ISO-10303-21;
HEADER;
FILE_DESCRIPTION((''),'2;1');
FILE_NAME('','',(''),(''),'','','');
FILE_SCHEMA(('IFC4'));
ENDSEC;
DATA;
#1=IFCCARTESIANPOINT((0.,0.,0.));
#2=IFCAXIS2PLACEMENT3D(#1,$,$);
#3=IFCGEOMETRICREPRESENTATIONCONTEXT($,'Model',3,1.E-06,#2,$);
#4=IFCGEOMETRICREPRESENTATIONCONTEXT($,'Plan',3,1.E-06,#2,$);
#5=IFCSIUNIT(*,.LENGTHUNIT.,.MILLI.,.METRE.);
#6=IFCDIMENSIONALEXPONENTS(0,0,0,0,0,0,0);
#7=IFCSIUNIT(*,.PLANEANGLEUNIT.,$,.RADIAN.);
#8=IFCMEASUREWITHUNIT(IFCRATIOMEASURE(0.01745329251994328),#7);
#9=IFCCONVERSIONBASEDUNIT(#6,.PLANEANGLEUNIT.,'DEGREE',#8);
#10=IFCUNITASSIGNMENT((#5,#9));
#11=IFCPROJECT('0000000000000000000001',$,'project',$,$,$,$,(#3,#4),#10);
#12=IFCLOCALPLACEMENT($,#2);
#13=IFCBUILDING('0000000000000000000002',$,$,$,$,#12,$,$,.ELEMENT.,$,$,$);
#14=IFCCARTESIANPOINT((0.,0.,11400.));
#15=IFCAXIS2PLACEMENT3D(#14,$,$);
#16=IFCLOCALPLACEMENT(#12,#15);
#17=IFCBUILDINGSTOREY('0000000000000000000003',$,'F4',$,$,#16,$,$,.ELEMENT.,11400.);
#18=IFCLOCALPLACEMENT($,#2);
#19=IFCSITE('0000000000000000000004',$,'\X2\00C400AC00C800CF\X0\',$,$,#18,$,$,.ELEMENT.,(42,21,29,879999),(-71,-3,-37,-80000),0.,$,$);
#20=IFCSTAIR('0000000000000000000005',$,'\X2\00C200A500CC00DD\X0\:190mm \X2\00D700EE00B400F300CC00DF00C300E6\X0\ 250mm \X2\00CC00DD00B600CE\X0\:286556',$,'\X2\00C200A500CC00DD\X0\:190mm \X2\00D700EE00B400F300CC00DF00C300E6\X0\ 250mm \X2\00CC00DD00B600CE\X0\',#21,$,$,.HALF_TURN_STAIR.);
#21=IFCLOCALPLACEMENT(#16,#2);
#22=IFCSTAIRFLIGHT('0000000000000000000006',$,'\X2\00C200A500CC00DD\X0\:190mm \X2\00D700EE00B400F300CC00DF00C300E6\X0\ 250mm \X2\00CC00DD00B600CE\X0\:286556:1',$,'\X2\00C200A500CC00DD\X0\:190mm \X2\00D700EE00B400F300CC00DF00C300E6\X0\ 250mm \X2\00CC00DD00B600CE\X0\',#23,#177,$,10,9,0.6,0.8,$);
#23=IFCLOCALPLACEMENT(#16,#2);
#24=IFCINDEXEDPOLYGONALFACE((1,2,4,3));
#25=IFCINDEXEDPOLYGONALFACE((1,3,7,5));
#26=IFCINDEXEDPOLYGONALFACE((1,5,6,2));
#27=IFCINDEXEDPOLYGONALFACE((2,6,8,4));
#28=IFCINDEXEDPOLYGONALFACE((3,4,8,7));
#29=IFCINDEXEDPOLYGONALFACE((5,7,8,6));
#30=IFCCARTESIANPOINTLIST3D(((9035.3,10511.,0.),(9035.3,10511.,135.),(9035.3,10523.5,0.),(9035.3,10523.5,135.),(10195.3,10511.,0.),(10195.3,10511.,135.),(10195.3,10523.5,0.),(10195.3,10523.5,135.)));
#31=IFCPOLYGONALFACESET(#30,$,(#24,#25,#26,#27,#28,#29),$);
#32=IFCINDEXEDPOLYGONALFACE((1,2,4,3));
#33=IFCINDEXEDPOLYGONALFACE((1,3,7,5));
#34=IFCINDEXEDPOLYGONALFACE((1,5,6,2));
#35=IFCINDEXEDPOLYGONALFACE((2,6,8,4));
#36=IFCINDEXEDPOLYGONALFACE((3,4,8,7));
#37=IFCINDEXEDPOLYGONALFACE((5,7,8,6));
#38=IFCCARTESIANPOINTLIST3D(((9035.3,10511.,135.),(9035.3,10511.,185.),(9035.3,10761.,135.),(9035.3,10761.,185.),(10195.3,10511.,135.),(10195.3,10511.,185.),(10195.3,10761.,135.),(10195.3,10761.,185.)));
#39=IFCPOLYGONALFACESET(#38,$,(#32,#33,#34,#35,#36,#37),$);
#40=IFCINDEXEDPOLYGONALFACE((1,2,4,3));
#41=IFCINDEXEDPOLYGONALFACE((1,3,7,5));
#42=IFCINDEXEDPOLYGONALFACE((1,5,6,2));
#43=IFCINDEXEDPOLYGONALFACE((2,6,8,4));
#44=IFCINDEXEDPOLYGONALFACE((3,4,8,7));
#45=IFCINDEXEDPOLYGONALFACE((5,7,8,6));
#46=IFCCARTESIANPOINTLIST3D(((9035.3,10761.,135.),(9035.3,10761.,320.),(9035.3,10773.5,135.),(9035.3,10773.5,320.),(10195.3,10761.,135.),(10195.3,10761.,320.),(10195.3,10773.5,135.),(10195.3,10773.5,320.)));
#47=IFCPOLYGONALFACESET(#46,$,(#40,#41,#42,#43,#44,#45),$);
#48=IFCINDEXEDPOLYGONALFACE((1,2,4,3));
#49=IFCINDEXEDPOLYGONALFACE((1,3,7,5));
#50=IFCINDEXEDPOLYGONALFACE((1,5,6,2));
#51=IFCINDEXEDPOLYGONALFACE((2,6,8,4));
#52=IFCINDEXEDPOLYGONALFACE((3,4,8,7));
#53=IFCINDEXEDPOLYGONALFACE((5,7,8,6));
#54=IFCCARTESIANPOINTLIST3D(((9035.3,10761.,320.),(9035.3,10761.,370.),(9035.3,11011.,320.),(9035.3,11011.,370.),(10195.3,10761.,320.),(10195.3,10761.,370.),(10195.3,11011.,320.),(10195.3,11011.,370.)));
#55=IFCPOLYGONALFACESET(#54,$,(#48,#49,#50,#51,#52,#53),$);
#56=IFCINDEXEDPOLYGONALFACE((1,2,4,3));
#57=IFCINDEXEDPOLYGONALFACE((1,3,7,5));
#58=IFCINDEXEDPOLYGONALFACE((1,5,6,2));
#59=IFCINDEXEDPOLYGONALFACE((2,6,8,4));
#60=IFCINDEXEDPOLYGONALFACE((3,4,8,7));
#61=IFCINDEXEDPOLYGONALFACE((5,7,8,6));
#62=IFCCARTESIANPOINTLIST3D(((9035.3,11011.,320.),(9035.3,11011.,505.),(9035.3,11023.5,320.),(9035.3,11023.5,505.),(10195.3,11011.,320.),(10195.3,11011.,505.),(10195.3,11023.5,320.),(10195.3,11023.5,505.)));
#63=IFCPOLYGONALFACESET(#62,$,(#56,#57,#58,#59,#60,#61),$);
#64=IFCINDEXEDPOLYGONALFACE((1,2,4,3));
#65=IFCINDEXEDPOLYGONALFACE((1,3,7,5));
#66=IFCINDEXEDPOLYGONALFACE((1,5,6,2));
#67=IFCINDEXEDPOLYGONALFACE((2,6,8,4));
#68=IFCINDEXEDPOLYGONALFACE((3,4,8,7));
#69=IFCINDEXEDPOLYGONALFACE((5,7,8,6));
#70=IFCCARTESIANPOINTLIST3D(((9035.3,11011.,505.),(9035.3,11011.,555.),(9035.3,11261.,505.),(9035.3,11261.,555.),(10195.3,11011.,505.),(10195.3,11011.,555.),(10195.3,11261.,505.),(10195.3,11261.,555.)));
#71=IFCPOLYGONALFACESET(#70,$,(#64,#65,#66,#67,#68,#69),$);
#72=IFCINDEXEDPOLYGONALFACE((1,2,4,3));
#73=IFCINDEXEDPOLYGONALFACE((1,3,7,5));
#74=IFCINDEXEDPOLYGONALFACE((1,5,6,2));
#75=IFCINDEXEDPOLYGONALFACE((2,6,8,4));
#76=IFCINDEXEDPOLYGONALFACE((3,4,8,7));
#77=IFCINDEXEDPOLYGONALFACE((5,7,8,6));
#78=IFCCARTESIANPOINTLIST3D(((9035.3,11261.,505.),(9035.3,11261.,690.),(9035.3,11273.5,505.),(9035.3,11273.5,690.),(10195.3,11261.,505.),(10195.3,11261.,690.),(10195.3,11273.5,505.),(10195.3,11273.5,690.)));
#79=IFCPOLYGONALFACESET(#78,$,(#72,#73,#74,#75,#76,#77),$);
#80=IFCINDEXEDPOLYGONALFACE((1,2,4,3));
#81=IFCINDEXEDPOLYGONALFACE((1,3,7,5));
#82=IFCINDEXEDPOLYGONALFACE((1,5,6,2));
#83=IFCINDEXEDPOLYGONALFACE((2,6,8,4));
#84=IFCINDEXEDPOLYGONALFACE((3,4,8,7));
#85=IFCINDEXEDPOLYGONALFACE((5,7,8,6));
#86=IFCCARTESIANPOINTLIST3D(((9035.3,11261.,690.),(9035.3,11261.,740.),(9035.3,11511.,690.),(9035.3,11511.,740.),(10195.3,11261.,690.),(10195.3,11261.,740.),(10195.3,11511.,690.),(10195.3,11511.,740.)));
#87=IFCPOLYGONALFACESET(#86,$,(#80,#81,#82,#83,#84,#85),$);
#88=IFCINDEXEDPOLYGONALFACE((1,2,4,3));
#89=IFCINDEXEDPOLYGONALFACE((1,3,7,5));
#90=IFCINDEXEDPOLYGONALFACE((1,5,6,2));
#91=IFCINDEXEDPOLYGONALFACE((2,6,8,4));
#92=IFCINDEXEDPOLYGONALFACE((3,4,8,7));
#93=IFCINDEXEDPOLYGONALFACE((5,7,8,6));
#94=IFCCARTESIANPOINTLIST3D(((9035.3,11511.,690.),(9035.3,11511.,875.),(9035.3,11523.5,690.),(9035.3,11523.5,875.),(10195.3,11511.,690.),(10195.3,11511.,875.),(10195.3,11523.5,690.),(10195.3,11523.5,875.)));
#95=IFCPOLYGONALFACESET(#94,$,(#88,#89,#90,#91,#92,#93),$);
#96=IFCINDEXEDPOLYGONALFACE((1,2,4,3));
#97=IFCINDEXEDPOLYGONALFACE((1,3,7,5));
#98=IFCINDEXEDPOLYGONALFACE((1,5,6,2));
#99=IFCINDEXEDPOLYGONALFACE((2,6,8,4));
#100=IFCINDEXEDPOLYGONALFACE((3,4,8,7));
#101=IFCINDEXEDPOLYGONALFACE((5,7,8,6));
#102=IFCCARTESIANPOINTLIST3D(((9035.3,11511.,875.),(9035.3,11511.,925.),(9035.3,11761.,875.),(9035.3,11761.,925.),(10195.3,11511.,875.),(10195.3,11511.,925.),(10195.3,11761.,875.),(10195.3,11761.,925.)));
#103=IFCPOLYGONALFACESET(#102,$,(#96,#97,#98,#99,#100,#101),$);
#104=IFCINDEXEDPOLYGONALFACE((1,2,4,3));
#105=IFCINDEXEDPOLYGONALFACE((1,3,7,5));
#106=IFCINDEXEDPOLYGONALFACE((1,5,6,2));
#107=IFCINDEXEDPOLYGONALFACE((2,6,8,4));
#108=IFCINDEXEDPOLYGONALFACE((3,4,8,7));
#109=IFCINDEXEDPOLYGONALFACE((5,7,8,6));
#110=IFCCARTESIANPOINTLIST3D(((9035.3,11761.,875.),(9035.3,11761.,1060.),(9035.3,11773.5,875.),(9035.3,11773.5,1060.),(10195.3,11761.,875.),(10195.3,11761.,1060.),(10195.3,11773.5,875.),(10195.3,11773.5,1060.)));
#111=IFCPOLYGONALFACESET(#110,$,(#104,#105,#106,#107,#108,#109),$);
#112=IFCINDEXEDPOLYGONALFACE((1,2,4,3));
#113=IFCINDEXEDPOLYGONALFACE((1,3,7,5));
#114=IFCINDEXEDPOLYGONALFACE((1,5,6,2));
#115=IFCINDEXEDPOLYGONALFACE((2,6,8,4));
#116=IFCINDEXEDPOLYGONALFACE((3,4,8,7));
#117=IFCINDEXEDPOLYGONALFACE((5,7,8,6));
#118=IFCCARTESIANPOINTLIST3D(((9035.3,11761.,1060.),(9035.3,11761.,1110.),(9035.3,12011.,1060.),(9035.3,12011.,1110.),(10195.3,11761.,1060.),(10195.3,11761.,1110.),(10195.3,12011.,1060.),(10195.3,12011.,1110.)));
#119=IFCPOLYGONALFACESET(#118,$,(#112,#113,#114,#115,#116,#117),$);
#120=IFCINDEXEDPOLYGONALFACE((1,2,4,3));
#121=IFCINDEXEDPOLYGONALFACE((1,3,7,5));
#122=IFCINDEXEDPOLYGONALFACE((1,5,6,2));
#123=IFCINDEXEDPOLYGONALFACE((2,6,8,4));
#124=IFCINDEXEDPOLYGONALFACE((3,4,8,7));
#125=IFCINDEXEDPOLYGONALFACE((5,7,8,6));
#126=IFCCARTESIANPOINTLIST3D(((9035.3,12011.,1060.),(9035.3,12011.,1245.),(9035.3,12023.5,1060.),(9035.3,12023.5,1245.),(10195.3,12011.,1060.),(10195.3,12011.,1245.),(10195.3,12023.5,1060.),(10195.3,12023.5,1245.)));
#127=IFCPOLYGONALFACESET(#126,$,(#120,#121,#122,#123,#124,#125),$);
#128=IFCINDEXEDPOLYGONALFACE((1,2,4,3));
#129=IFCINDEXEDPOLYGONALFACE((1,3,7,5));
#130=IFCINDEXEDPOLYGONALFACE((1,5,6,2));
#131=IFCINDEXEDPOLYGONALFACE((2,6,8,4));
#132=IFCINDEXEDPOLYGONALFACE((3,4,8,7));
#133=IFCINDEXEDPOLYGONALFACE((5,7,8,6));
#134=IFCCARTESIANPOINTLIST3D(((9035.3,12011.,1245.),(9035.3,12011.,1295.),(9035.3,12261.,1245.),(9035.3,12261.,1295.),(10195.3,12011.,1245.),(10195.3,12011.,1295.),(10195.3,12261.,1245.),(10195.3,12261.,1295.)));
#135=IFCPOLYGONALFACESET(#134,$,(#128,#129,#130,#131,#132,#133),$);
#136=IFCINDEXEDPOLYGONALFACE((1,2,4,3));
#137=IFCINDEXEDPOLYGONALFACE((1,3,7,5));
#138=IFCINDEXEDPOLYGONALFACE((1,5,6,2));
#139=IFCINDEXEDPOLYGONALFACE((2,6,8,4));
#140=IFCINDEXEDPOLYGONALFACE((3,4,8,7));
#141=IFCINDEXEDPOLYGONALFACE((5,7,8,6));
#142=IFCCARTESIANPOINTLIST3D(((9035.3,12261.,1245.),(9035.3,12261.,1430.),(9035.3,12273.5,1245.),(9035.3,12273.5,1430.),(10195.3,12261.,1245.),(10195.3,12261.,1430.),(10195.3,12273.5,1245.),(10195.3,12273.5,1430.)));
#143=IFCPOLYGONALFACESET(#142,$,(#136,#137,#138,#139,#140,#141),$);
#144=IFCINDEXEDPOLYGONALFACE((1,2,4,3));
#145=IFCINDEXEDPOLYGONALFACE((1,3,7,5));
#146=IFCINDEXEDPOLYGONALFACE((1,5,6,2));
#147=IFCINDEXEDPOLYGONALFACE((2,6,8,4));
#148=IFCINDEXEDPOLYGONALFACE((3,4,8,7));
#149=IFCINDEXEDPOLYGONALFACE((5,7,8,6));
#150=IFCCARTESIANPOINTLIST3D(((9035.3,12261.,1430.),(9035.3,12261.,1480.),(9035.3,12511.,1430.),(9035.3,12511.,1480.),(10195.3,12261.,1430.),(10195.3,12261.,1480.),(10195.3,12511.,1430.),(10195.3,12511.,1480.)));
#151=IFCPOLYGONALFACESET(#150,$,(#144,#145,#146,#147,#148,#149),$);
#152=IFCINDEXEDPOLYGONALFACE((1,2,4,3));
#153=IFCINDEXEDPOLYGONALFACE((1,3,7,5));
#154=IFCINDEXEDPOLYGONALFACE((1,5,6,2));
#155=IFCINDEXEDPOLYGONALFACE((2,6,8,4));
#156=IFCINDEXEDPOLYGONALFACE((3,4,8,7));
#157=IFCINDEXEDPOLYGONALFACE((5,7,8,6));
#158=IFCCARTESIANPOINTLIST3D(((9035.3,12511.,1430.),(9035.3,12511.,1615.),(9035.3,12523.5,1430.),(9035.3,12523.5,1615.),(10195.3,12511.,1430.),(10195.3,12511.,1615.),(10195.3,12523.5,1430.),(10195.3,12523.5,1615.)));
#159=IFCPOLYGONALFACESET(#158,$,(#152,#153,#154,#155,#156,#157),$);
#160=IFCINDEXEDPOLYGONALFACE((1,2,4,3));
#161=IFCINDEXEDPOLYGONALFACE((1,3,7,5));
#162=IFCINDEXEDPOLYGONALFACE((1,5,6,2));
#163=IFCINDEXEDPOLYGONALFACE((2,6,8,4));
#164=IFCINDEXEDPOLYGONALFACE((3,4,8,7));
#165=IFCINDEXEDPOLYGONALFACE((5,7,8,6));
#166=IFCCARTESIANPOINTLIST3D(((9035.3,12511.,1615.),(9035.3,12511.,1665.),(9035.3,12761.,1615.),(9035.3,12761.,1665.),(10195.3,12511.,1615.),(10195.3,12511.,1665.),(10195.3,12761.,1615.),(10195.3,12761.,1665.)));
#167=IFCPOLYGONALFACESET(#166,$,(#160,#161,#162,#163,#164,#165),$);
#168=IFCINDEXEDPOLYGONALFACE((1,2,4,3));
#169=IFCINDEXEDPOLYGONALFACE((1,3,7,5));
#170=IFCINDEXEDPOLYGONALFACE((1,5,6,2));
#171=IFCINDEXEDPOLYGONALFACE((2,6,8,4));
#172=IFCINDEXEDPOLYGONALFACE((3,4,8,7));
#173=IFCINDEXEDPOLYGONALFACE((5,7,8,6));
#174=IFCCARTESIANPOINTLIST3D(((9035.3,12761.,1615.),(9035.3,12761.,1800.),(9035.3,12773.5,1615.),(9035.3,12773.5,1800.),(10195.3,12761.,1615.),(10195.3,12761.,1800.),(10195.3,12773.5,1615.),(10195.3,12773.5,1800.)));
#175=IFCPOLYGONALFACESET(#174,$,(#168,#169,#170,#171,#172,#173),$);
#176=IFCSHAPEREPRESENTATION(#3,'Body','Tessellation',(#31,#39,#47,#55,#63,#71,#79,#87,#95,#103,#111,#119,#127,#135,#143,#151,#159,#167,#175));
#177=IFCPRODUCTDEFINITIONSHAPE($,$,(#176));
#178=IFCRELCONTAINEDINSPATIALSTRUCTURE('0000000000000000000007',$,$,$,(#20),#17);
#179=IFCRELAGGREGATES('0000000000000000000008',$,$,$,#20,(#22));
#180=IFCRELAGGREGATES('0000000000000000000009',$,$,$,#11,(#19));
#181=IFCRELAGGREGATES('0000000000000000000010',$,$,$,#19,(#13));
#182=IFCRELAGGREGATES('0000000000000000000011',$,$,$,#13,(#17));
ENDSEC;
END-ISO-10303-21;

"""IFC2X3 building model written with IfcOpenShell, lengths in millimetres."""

from ifc_helpers import new_model, entity, si_unit, converted_unit, frame, origin, origin_2d_with_axis, place, context, project, spatial, rectangle, extrude, element, aggregate, save


model = new_model("IFC2X3")

# Units and contexts
model_context = context("Model", 3, precision=1e-06, world=origin())
plan_context = context("Plan", 3, precision=1e-06, world=origin())
ifc_project = project(units=[si_unit("LENGTHUNIT", "METRE", prefix="MILLI"), converted_unit("PLANEANGLEUNIT", "DEGREE", entity("IfcRatioMeasure", 0.01745329251994328), si_unit("PLANEANGLEUNIT", "RADIAN"), dimensions=[0, 0, 0, 0, 0, 0, 0])], contexts=[model_context, plan_context])

# Site, building, storey
site_placement = place(None, origin())
site = spatial("IfcSite", under=ifc_project, at=site_placement, Name="Ä¬ÈÏ", CompositionType="ELEMENT", RefLatitude=(42, 21, 29, 879999), RefLongitude=(-71, -3, -37, -80000), RefElevation=0.0)
building_placement = place(None, origin())
building = spatial("IfcBuilding", under=site, at=building_placement, CompositionType="ELEMENT")
storey_placement = place(building_placement, frame((0.0, 0.0, 11400.0)))
storey = spatial("IfcBuildingStorey", under=building, at=storey_placement, Name="F4", CompositionType="ELEMENT", Elevation=11400.0)

# Stair
stair_1_placement = place(storey_placement, origin())
stair_1 = element("IfcStair", 1, at=stair_1_placement, inside=storey, Name="Â¥ÌÝ:190mm ×î´óÌßÃæ 250mm ÌÝ¶Î:286556", ObjectType="Â¥ÌÝ:190mm ×î´óÌßÃæ 250mm ÌÝ¶Î", ShapeType="HALF_TURN_STAIR")

# Stair flight
stair_flight_1_placement = place(storey_placement, origin())
stair_flight_1 = element("IfcStairFlight", 2, at=stair_flight_1_placement, Name="Â¥ÌÝ:190mm ×î´óÌßÃæ 250mm ÌÝ¶Î:286556:1", ObjectType="Â¥ÌÝ:190mm ×î´óÌßÃæ 250mm ÌÝ¶Î", NumberOfRiser=10, NumberOfTreads=9, RiserHeight=0.6, TreadLength=0.8, context=model_context, shape_type="SweptSolid", body=[
    extrude(rectangle(XDim=1160.0, YDim=12.5, at=origin_2d_with_axis()), frame((9615.3, 10517.3, 0.0), z_axis=(0.0, 0.0, 1.0), x_axis=(-1.0, 0.0, 0.0)), (0.0, 0.0, 1.0), 135.0),
    extrude(rectangle(XDim=250.0, YDim=1160.0, at=origin_2d_with_axis()), frame((9615.3, 10636.0, 135.0), z_axis=(0.0, 0.0, 1.0), x_axis=(0.0, -1.0, 0.0)), (0.0, 0.0, 1.0), 50.0),
    extrude(rectangle(XDim=1160.0, YDim=12.5, at=origin_2d_with_axis()), frame((9615.3, 10767.3, 135.0), z_axis=(0.0, 0.0, 1.0), x_axis=(-1.0, 0.0, 0.0)), (0.0, 0.0, 1.0), 185.0),
    extrude(rectangle(XDim=250.0, YDim=1160.0, at=origin_2d_with_axis()), frame((9615.3, 10886.0, 320.0), z_axis=(0.0, 0.0, 1.0), x_axis=(0.0, -1.0, 0.0)), (0.0, 0.0, 1.0), 50.0),
    extrude(rectangle(XDim=1160.0, YDim=12.5, at=origin_2d_with_axis()), frame((9615.3, 11017.3, 320.0), z_axis=(0.0, 0.0, 1.0), x_axis=(-1.0, 0.0, 0.0)), (0.0, 0.0, 1.0), 185.0),
    extrude(rectangle(XDim=250.0, YDim=1160.0, at=origin_2d_with_axis()), frame((9615.3, 11136.0, 505.0), z_axis=(0.0, 0.0, 1.0), x_axis=(0.0, -1.0, 0.0)), (0.0, 0.0, 1.0), 50.0),
    extrude(rectangle(XDim=1160.0, YDim=12.5, at=origin_2d_with_axis()), frame((9615.3, 11267.3, 505.0), z_axis=(0.0, 0.0, 1.0), x_axis=(-1.0, 0.0, 0.0)), (0.0, 0.0, 1.0), 185.0),
    extrude(rectangle(XDim=250.0, YDim=1160.0, at=origin_2d_with_axis()), frame((9615.3, 11386.0, 690.0), z_axis=(0.0, 0.0, 1.0), x_axis=(0.0, -1.0, 0.0)), (0.0, 0.0, 1.0), 50.0),
    extrude(rectangle(XDim=1160.0, YDim=12.5, at=origin_2d_with_axis()), frame((9615.3, 11517.3, 690.0), z_axis=(0.0, 0.0, 1.0), x_axis=(-1.0, 0.0, 0.0)), (0.0, 0.0, 1.0), 185.0),
    extrude(rectangle(XDim=250.0, YDim=1160.0, at=origin_2d_with_axis()), frame((9615.3, 11636.0, 875.0), z_axis=(0.0, 0.0, 1.0), x_axis=(0.0, -1.0, 0.0)), (0.0, 0.0, 1.0), 50.0),
    extrude(rectangle(XDim=1160.0, YDim=12.5, at=origin_2d_with_axis()), frame((9615.3, 11767.3, 875.0), z_axis=(0.0, 0.0, 1.0), x_axis=(-1.0, 0.0, 0.0)), (0.0, 0.0, 1.0), 185.0),
    extrude(rectangle(XDim=250.0, YDim=1160.0, at=origin_2d_with_axis()), frame((9615.3, 11886.0, 1060.0), z_axis=(0.0, 0.0, 1.0), x_axis=(0.0, -1.0, 0.0)), (0.0, 0.0, 1.0), 50.0),
    extrude(rectangle(XDim=1160.0, YDim=12.5, at=origin_2d_with_axis()), frame((9615.3, 12017.3, 1060.0), z_axis=(0.0, 0.0, 1.0), x_axis=(-1.0, 0.0, 0.0)), (0.0, 0.0, 1.0), 185.0),
    extrude(rectangle(XDim=250.0, YDim=1160.0, at=origin_2d_with_axis()), frame((9615.3, 12136.0, 1245.0), z_axis=(0.0, 0.0, 1.0), x_axis=(0.0, -1.0, 0.0)), (0.0, 0.0, 1.0), 50.0),
    extrude(rectangle(XDim=1160.0, YDim=12.5, at=origin_2d_with_axis()), frame((9615.3, 12267.3, 1245.0), z_axis=(0.0, 0.0, 1.0), x_axis=(-1.0, 0.0, 0.0)), (0.0, 0.0, 1.0), 185.0),
    extrude(rectangle(XDim=250.0, YDim=1160.0, at=origin_2d_with_axis()), frame((9615.3, 12386.0, 1430.0), z_axis=(0.0, 0.0, 1.0), x_axis=(0.0, -1.0, 0.0)), (0.0, 0.0, 1.0), 50.0),
    extrude(rectangle(XDim=1160.0, YDim=12.5, at=origin_2d_with_axis()), frame((9615.3, 12517.3, 1430.0), z_axis=(0.0, 0.0, 1.0), x_axis=(-1.0, 0.0, 0.0)), (0.0, 0.0, 1.0), 185.0),
    extrude(rectangle(XDim=250.0, YDim=1160.0, at=origin_2d_with_axis()), frame((9615.3, 12636.0, 1615.0), z_axis=(0.0, 0.0, 1.0), x_axis=(0.0, -1.0, 0.0)), (0.0, 0.0, 1.0), 50.0),
    extrude(rectangle(XDim=1160.0, YDim=12.5, at=origin_2d_with_axis()), frame((9615.3, 12767.3, 1615.0), z_axis=(0.0, 0.0, 1.0), x_axis=(-1.0, 0.0, 0.0)), (0.0, 0.0, 1.0), 185.0),
])

aggregate(stair_1, [stair_flight_1])

save(model, "model.ifc")
